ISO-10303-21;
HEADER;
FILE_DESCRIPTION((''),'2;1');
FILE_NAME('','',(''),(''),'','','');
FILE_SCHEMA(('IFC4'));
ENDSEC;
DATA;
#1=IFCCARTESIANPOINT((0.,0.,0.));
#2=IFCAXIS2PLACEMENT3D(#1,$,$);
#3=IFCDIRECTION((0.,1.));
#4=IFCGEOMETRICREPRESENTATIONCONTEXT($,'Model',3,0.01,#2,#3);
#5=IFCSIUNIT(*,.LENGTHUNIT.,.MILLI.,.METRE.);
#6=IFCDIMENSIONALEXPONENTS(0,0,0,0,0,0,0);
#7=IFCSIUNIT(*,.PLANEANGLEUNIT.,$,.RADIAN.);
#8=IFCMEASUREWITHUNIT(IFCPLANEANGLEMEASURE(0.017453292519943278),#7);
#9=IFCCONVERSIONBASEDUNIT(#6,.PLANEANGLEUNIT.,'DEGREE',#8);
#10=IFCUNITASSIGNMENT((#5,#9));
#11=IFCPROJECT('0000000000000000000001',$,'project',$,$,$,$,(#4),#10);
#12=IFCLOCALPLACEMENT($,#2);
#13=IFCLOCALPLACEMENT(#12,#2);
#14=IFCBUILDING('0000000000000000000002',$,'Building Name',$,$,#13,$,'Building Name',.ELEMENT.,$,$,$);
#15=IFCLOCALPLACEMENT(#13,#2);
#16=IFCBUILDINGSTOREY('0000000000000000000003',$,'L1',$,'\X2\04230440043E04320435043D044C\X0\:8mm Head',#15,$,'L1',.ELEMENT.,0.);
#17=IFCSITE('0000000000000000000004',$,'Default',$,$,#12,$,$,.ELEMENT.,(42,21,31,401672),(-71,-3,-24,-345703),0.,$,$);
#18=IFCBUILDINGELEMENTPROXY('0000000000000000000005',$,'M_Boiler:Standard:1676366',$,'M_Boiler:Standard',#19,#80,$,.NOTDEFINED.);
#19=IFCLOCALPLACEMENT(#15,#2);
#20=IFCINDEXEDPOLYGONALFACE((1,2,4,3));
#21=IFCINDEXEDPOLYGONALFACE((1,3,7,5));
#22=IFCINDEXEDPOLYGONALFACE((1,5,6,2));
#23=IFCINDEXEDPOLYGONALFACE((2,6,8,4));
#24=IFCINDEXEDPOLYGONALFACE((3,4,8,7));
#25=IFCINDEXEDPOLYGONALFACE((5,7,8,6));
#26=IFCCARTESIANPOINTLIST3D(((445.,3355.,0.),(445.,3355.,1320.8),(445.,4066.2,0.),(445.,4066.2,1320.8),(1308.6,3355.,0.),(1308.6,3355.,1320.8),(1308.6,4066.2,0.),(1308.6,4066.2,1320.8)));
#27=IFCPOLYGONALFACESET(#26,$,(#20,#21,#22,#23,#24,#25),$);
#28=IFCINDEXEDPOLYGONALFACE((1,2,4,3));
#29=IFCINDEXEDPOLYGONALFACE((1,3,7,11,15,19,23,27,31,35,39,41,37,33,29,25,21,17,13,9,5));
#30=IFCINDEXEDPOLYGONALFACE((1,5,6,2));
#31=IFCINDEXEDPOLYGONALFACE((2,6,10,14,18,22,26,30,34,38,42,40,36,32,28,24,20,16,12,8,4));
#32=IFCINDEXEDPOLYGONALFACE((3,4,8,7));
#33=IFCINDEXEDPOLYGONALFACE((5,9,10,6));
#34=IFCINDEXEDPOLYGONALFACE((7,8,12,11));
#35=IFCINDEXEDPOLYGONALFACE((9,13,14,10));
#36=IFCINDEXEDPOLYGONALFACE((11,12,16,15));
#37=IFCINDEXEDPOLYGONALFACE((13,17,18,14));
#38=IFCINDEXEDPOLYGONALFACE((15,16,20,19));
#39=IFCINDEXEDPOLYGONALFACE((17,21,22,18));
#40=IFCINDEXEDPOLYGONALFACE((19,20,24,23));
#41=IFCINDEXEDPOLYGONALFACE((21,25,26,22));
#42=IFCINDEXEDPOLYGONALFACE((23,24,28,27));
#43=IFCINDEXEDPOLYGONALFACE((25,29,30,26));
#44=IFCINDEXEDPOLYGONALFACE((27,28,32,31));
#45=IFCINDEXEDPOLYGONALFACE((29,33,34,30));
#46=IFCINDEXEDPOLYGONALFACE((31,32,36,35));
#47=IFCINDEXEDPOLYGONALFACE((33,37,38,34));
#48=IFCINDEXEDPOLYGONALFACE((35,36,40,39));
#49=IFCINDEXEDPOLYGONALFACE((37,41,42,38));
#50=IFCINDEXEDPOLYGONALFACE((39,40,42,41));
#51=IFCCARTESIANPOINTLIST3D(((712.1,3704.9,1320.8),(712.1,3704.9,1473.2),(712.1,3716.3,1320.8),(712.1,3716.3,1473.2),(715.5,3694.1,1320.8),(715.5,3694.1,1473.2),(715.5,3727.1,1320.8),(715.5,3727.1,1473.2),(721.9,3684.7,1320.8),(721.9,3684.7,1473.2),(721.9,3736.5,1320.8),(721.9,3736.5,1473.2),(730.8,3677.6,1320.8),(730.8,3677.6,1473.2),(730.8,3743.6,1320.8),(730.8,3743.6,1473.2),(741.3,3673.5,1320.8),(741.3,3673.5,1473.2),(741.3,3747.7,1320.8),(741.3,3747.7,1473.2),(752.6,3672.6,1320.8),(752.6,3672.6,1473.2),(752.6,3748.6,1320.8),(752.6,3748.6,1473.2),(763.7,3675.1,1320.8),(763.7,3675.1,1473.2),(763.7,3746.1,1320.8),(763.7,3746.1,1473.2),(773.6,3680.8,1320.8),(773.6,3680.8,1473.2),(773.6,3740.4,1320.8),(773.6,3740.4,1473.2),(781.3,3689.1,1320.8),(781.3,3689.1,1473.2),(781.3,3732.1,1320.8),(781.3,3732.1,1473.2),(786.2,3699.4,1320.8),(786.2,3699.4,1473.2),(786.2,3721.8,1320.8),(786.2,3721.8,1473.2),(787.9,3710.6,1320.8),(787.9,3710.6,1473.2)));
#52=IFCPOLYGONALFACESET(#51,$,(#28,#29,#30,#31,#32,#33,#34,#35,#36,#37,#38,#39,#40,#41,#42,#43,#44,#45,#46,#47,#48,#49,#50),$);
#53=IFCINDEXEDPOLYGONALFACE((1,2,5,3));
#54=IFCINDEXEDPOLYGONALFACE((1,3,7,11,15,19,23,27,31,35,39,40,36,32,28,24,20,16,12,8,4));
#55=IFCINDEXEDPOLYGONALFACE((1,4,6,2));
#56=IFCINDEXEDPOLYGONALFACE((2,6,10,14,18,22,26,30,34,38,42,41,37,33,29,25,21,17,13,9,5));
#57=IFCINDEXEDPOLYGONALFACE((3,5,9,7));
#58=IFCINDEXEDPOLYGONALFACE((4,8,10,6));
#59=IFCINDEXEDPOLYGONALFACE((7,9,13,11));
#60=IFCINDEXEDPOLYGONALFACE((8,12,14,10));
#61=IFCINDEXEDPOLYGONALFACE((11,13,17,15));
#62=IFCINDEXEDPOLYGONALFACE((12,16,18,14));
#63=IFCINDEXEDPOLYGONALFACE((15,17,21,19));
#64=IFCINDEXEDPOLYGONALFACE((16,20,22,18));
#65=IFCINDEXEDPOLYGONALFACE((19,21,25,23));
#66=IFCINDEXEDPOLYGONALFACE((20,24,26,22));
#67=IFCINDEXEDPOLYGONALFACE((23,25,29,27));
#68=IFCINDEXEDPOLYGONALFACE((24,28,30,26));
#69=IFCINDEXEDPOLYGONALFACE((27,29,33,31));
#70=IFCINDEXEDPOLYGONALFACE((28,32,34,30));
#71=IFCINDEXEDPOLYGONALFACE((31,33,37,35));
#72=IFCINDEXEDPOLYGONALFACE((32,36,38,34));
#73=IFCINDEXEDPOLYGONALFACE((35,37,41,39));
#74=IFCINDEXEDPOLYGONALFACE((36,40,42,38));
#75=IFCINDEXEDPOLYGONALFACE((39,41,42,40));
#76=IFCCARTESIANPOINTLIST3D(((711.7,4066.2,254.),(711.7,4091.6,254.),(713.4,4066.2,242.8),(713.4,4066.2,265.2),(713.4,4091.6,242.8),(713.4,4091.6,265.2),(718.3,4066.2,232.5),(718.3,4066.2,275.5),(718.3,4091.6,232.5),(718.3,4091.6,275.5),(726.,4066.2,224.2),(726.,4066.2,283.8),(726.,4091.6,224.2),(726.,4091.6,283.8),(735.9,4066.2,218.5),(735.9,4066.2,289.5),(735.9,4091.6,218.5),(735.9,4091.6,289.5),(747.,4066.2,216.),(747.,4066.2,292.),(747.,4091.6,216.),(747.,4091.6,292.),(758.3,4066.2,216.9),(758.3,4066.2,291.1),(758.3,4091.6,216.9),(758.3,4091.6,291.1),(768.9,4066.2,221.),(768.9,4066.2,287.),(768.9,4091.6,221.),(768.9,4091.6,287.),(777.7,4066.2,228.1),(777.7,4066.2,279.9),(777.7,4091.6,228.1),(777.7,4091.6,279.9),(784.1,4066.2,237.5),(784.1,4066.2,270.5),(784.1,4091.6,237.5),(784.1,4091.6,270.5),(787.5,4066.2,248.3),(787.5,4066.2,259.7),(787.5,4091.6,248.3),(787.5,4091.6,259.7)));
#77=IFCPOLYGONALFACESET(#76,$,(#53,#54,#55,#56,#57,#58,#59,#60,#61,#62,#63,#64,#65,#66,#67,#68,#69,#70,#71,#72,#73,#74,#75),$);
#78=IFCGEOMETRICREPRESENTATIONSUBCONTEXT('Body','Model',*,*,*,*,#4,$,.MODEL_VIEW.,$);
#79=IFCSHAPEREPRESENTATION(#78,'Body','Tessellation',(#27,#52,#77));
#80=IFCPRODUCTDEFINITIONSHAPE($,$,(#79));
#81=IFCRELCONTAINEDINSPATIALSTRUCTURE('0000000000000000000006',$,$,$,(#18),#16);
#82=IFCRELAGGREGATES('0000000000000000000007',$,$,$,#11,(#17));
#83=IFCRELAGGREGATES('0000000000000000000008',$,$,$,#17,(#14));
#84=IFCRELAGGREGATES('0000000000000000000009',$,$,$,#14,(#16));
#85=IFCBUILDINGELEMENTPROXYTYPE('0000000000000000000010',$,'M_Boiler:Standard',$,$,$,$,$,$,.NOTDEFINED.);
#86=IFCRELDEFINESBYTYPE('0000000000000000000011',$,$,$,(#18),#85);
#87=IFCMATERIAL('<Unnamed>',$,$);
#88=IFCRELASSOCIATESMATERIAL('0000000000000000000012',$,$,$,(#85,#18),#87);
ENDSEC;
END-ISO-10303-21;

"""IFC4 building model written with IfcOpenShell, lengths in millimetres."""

from ifc_helpers import new_model, entity, si_unit, converted_unit, direction, frame, frame_2d, origin, place, context, subcontext, project, spatial, rectangle, circle, extrude, source, transform, mapped, material, type_object, type_shapes, element, save


model = new_model("IFC4")

# Units and contexts
model_context = context("Model", 3, precision=0.01, world=origin(), true_north=direction((0.0, 1.0)))
body_context = subcontext(model_context, "Body", "Model", "MODEL_VIEW")
ifc_project = project(units=[si_unit("LENGTHUNIT", "METRE", prefix="MILLI"), converted_unit("PLANEANGLEUNIT", "DEGREE", entity("IfcPlaneAngleMeasure", 0.017453292519943278), si_unit("PLANEANGLEUNIT", "RADIAN"), dimensions=[0, 0, 0, 0, 0, 0, 0])], contexts=[model_context])

# Site, building, storey
site_placement = place(None, origin())
site = spatial("IfcSite", under=ifc_project, at=site_placement, Name="Default", CompositionType="ELEMENT", RefLatitude=(42, 21, 31, 401672), RefLongitude=(-71, -3, -24, -345703), RefElevation=0.0)
building_placement = place(site_placement, origin())
building = spatial("IfcBuilding", under=site, at=building_placement, Name="Building Name", LongName="Building Name", CompositionType="ELEMENT")
storey_placement = place(building_placement, origin())
storey = spatial("IfcBuildingStorey", under=building, at=storey_placement, Name="L1", ObjectType="Уровень:8mm Head", LongName="L1", CompositionType="ELEMENT", Elevation=0.0)

# Building element proxy
ifc_material_1 = material(Name="<Unnamed>")
building_element_proxy_type_1 = type_object("IfcBuildingElementProxyType", Name="M_Boiler:Standard", PredefinedType="NOTDEFINED", material=ifc_material_1)
shared_shape_1 = source(origin(), body_context, "Body", "SweptSolid", [
    extrude(rectangle(XDim=711.2, YDim=863.6, at=frame_2d((0.0, 0.0), x_axis=(1.0, 0.0))), frame((431.8, 355.6, 0.0), z_axis=(0.0, 0.0, 1.0), x_axis=(0.0, 1.0, 0.0)), (0.0, 0.0, 1.0), 1320.8),
    extrude(circle(Radius=38.1, at=frame_2d((0.0, 0.0), x_axis=(1.0, 0.0))), frame((304.8, 355.6, 1320.8)), (0.0, 0.0, 1.0), 152.4),
    extrude(circle(Radius=38.1, at=frame_2d((0.0, 0.0), x_axis=(1.0, 0.0))), frame((304.8, 711.2, 254.0), z_axis=(0.0, 1.0, 0.0), x_axis=(-1.0, 0.0, 0.0)), (0.0, 0.0, 1.0), 25.4),
])
type_shapes(building_element_proxy_type_1, [shared_shape_1])
proxy_1_placement = place(storey_placement, frame((445.0, 3355.0, 0.0)))
element("IfcBuildingElementProxy", 1, at=proxy_1_placement, inside=storey, type_object=building_element_proxy_type_1, material=ifc_material_1, Name="M_Boiler:Standard:1676366", ObjectType="M_Boiler:Standard", PredefinedType="NOTDEFINED", context=body_context, shape_type="MappedRepresentation", body=[
    mapped(shared_shape_1, transform((0.0, 0.0, 0.0), scale=1.0)),
])

save(model, "model.ifc")
